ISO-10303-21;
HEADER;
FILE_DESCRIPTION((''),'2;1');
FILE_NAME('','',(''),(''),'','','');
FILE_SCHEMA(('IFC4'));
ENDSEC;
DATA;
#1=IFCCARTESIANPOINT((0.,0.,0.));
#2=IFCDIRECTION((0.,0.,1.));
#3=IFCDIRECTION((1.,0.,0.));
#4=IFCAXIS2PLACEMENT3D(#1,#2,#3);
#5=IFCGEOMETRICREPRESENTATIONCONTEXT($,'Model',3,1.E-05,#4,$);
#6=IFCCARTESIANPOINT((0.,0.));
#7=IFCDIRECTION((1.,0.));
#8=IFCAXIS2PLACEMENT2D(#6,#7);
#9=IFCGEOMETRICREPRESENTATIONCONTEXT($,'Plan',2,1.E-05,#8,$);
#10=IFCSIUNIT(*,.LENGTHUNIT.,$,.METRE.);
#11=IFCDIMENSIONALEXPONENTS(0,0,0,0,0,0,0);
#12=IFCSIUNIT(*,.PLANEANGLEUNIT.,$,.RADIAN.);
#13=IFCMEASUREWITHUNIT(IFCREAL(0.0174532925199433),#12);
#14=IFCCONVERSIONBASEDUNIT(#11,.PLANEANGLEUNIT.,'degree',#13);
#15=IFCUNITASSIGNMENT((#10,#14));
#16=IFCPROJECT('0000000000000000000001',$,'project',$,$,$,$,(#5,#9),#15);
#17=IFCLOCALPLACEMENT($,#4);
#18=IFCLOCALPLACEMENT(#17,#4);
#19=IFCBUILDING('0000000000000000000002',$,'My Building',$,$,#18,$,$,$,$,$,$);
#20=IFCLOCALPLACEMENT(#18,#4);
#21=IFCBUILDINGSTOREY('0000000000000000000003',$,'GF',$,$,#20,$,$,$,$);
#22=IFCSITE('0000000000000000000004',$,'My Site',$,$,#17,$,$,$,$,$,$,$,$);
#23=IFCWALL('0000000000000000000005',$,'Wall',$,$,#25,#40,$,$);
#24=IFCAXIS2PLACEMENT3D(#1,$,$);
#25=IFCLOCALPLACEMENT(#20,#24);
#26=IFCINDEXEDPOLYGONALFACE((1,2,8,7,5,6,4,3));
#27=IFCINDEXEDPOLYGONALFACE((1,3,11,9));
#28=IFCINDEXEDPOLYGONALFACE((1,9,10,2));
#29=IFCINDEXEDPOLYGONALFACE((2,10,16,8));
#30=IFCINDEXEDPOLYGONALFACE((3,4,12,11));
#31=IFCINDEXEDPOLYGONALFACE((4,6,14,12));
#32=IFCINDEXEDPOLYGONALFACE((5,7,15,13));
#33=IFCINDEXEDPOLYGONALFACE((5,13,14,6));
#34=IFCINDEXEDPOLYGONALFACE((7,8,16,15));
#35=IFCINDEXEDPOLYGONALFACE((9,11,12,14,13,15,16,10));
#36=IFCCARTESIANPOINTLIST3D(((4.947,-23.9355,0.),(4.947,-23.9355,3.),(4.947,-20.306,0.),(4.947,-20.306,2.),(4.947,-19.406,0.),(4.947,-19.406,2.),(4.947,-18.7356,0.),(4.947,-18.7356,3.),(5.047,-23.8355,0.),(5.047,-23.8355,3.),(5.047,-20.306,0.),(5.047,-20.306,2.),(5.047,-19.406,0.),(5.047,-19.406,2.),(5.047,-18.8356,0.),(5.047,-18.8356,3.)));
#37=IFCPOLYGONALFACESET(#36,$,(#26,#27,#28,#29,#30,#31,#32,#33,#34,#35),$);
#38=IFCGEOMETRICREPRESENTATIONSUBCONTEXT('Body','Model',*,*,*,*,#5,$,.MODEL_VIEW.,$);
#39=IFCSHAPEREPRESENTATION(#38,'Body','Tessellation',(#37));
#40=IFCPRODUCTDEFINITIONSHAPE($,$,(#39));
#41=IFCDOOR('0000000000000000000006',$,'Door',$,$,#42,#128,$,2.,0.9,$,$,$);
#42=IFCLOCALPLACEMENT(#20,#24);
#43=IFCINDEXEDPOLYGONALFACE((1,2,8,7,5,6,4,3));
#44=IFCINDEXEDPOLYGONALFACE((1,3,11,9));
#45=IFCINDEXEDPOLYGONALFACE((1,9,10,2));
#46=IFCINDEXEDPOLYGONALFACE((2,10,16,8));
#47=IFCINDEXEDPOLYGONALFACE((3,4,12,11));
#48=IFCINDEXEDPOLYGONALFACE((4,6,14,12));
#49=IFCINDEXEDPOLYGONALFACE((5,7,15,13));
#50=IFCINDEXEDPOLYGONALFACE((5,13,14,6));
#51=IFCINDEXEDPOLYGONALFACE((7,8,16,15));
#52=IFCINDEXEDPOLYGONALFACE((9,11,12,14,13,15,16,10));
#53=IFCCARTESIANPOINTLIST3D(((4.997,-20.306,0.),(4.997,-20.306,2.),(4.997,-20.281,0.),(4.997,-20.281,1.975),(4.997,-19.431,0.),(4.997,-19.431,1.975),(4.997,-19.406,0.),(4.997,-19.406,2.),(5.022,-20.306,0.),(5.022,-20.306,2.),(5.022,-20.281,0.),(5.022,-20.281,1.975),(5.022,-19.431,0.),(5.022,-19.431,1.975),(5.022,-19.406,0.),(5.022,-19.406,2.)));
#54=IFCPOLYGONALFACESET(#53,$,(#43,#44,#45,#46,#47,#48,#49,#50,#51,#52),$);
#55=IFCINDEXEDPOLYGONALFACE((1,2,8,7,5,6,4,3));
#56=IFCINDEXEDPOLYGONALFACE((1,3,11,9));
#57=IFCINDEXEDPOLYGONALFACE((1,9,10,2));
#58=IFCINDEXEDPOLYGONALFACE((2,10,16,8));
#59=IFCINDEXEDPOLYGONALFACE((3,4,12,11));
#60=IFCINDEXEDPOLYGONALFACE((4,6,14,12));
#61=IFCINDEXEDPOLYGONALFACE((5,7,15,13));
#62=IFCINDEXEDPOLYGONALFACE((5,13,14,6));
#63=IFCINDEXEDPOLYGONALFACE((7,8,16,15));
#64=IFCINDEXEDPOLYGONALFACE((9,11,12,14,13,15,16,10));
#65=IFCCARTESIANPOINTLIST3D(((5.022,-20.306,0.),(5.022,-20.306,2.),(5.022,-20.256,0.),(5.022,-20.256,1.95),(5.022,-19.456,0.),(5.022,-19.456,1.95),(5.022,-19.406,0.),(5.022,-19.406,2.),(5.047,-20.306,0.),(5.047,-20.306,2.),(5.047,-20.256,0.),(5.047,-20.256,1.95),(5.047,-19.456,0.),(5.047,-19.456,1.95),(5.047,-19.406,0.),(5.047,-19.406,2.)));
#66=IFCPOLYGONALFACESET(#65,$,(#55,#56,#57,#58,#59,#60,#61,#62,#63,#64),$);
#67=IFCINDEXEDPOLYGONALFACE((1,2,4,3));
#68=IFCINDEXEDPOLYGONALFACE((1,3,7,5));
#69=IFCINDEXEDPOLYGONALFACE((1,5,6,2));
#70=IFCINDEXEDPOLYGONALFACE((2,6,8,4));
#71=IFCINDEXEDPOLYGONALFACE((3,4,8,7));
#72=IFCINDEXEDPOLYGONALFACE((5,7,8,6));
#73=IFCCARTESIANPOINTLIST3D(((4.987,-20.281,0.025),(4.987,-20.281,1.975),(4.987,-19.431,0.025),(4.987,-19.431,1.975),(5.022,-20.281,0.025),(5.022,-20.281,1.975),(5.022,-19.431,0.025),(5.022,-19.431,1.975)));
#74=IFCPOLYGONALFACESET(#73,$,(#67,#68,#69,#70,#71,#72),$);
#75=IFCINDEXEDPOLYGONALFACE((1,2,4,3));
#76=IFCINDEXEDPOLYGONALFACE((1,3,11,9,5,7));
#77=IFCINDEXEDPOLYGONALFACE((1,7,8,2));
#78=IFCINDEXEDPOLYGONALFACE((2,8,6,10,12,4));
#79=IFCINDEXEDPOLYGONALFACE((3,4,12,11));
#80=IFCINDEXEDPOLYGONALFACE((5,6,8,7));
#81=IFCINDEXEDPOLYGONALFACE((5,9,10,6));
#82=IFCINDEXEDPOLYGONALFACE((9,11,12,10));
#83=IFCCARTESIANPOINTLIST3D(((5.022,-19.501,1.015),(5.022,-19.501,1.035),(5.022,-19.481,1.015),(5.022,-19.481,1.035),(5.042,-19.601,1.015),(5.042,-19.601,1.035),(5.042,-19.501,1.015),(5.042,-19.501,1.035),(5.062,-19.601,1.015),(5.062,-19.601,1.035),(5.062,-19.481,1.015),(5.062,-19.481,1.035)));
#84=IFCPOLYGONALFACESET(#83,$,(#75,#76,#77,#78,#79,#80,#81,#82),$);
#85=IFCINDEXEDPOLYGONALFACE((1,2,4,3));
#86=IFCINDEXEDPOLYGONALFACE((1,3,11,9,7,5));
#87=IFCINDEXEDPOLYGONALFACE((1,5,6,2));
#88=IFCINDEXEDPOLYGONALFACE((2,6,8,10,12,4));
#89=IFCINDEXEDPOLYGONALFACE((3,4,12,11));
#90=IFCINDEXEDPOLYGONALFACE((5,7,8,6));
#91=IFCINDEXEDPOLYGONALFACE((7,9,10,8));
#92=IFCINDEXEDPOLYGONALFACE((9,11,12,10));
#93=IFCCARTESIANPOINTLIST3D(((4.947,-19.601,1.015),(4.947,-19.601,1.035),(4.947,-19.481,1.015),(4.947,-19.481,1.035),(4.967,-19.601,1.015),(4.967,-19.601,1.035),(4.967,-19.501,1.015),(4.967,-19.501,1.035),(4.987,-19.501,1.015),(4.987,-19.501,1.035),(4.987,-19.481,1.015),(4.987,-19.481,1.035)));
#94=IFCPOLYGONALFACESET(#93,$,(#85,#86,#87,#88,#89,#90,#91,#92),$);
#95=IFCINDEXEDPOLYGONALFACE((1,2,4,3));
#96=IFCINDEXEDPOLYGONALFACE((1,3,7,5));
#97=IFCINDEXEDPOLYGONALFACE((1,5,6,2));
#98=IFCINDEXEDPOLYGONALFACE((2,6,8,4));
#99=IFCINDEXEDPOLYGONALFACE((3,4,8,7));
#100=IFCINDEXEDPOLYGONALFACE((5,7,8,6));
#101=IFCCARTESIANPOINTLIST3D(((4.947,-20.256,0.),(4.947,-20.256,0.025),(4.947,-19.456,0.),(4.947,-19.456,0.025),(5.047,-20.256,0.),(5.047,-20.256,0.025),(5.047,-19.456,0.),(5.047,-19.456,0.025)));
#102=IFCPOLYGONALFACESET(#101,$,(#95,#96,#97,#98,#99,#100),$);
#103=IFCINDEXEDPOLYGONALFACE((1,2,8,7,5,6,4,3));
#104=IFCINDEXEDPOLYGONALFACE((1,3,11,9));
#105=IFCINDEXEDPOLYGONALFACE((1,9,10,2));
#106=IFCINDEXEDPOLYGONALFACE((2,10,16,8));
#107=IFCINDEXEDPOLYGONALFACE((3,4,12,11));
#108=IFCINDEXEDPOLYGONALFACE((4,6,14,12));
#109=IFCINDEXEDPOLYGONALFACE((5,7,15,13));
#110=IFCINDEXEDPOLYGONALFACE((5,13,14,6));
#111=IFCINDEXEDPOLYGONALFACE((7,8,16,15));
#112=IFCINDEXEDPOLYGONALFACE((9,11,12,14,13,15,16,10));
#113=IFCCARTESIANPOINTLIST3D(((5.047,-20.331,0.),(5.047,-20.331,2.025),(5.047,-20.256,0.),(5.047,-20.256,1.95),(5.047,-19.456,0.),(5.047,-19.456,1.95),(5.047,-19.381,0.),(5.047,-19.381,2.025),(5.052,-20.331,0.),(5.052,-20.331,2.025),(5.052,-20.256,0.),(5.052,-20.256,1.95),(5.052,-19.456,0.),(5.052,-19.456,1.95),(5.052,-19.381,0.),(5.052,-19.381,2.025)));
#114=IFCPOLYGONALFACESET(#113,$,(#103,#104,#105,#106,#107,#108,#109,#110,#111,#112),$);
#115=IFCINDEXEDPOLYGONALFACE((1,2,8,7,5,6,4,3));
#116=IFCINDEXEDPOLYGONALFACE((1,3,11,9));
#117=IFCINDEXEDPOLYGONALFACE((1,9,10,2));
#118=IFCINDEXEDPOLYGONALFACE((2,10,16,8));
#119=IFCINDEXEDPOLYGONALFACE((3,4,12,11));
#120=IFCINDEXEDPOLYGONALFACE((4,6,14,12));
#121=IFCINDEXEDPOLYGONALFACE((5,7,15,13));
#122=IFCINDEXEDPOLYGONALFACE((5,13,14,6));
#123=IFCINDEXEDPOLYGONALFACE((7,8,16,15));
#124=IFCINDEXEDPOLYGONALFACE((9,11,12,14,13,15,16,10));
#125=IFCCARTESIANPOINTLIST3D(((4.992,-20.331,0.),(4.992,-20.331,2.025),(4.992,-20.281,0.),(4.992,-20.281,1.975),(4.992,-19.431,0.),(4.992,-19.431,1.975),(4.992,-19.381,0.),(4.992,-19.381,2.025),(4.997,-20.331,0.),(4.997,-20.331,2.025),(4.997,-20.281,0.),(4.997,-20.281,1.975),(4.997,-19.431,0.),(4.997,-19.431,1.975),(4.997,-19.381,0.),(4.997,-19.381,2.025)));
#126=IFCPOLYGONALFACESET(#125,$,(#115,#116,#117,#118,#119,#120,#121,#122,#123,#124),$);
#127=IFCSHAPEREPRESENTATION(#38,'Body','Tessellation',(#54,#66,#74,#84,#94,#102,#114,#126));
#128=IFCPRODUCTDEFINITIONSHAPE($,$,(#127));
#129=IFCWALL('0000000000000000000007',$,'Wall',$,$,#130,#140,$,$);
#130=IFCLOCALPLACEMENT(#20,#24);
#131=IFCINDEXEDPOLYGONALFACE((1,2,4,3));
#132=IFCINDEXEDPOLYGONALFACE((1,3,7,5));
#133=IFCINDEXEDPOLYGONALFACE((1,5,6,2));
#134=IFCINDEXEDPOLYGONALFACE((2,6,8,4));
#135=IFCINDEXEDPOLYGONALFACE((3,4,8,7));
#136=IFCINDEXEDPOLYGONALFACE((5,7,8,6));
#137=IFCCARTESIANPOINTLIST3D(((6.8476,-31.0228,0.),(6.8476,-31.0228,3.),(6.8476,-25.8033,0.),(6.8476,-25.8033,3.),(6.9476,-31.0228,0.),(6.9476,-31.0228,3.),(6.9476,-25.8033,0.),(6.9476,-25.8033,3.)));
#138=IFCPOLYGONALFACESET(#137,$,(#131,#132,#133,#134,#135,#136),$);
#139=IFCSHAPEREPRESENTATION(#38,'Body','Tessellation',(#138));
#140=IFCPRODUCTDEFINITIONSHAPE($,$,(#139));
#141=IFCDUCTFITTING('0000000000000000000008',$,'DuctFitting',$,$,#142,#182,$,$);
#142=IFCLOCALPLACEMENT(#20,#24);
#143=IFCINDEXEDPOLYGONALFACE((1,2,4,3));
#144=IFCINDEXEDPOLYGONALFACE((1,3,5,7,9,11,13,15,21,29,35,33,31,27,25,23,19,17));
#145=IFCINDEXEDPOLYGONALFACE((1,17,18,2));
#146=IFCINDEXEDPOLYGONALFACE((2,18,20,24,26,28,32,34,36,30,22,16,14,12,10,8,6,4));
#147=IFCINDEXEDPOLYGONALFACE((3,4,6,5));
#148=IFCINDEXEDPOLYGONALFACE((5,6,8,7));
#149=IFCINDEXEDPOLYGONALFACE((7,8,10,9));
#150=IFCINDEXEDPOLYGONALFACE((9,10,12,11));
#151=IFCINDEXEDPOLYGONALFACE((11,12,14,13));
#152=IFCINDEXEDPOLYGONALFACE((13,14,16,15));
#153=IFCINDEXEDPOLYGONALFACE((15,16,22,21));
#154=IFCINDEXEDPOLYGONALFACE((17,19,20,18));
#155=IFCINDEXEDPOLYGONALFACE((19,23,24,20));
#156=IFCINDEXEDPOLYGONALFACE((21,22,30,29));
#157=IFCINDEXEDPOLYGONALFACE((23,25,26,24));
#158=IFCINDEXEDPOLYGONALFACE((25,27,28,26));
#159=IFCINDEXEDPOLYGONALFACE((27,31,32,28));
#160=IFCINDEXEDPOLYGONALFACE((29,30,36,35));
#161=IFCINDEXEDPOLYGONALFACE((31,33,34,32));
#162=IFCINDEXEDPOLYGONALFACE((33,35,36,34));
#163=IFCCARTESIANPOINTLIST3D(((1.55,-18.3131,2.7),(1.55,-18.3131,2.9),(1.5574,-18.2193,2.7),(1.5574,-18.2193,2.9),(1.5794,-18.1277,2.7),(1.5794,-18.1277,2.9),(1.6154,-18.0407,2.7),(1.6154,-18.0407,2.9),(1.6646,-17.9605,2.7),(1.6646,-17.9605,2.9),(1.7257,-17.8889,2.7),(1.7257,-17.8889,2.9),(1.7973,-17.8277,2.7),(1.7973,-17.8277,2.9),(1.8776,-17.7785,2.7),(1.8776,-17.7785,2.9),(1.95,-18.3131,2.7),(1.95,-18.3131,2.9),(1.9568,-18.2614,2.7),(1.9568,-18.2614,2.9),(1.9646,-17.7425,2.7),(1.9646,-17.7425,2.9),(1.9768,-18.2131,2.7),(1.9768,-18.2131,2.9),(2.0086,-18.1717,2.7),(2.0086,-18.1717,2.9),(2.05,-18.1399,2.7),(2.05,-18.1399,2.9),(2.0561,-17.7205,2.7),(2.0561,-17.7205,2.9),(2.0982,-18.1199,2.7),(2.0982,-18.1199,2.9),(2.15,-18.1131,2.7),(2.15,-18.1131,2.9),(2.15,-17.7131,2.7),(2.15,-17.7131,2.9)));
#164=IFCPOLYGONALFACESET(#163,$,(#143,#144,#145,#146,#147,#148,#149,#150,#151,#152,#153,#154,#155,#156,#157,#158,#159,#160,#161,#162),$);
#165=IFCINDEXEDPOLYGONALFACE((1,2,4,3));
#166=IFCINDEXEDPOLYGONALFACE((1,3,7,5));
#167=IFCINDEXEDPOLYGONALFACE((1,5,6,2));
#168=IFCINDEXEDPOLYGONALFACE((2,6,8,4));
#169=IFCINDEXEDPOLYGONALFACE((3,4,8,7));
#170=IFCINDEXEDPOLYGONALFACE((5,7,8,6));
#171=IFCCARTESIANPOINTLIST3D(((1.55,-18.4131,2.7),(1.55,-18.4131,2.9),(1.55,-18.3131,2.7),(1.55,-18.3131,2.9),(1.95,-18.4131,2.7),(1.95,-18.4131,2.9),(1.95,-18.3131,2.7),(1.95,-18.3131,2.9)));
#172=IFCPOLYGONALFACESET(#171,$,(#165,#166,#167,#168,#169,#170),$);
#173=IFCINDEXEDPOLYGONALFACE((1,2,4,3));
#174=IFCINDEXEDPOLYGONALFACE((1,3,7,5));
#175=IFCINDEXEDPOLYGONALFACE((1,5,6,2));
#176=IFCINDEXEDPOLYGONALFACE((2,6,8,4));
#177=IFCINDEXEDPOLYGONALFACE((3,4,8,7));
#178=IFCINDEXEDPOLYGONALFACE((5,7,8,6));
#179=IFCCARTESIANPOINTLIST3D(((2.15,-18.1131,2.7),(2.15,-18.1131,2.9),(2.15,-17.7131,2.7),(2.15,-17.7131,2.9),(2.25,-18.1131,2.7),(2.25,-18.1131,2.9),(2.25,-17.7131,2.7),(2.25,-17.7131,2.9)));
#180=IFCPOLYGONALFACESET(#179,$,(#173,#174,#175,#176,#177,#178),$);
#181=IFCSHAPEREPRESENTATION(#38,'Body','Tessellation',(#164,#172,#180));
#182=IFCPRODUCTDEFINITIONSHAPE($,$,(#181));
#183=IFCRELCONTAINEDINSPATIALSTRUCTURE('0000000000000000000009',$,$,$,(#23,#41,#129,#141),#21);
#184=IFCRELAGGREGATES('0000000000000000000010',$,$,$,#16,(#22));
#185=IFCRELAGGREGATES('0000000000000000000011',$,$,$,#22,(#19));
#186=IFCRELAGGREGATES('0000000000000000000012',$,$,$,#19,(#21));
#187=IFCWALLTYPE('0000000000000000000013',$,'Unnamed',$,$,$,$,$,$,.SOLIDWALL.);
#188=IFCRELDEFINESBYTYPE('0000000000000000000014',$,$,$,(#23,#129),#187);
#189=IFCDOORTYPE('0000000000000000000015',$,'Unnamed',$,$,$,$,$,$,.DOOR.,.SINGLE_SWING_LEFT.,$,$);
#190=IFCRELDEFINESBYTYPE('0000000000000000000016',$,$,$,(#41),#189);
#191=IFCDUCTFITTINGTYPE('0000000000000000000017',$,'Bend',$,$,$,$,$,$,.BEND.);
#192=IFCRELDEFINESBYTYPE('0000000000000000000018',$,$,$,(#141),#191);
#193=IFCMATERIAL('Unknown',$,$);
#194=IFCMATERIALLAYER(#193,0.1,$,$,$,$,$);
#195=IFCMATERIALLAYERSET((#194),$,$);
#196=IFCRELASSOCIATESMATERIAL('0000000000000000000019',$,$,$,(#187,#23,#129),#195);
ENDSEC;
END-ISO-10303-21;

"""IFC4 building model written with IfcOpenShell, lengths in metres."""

from ifc_helpers import new_model, entity, si_unit, converted_unit, frame, origin_with_axes, origin_2d_with_axis, place, context, subcontext, project, spatial, line, arc, indexed_curve, rectangle, outline, extrude, shape, source, transform, mapped, material, layer, layer_set, layer_usage, type_object, type_shapes, element, fill, save


model = new_model("IFC4")

# Units and contexts
model_context = context("Model", 3, precision=1e-05, world=origin_with_axes())
plan_context = context("Plan", 2, precision=1e-05, world=origin_2d_with_axis())
body_context_1 = subcontext(model_context, "Body", "Model", "MODEL_VIEW")
body_context_2 = subcontext(plan_context, "Body", "Plan", "PLAN_VIEW")
ifc_project = project(units=[si_unit("LENGTHUNIT", "METRE"), converted_unit("PLANEANGLEUNIT", "degree", entity("IfcReal", 0.0174532925199433), si_unit("PLANEANGLEUNIT", "RADIAN"), dimensions=[0, 0, 0, 0, 0, 0, 0])], contexts=[model_context, plan_context])

# Site, building, storey
site_placement = place(None, origin_with_axes())
site = spatial("IfcSite", under=ifc_project, at=site_placement, Name="My Site")
building_placement = place(site_placement, origin_with_axes())
building = spatial("IfcBuilding", under=site, at=building_placement, Name="My Building")
storey_placement = place(building_placement, origin_with_axes())
storey = spatial("IfcBuildingStorey", under=building, at=storey_placement, Name="GF")

# Shared definitions
ifc_material = material(Name="Unknown")

# Shared definitions
ifc_layer_1 = layer(ifc_material, 0.1)
ifc_layer_set_1 = layer_set([ifc_layer_1])
wall_type = type_object("IfcWallType", Name="Unnamed", PredefinedType="SOLIDWALL", material=ifc_layer_set_1)

# Shared definitions
shared_shape_1 = source(origin_with_axes(), body_context_1, "Body", "SweptSolid", [
    extrude(outline(indexed_curve([(0.0, 0.0), (0.9, 0.0), (0.9, 2.0), (0.0, 2.0)], segments=[line(1, 2, 3, 4, 1)])), frame((0.0, -0.6, 0.0), z_axis=(0.0, -1.0, 0.0), x_axis=(1.0, 0.0, 0.0)), (0.0, 0.0, -1.0), 1.2),
])
door_type = type_object("IfcDoorType", Name="Unnamed", OperationType="SINGLE_SWING_LEFT", PredefinedType="DOOR")
shared_shape_2 = source(origin_with_axes(), body_context_1, "Body", "SweptSolid", [
    extrude(outline(indexed_curve([(0.0, 0.0), (0.0, 2.0), (0.9, 2.0), (0.9, 0.0), (0.875, 0.0), (0.875, 1.975), (0.025, 1.975), (0.025, 0.0)], segments=[line(1, 2, 3, 4, 5, 6, 7, 8, 1)])), frame((0.0, 0.025, 0.0), z_axis=(0.0, -1.0, 0.0), x_axis=(1.0, 0.0, 0.0)), (0.0, 0.0, -1.0), 0.025),
    extrude(outline(indexed_curve([(0.0, 0.0), (0.0, 2.0), (0.9, 2.0), (0.9, 0.0), (0.85, 0.0), (0.85, 1.95), (0.05, 1.95), (0.05, 0.0)], segments=[line(1, 2, 3, 4, 5, 6, 7, 8, 1)])), frame((0.0, 0.0, 0.0), z_axis=(0.0, -1.0, 0.0), x_axis=(1.0, 0.0, 0.0)), (0.0, 0.0, -1.0), 0.025),
    extrude(outline(indexed_curve([(0.0, 0.0), (0.85, 0.0), (0.85, 0.035), (0.0, 0.035)], segments=[line(1, 2, 3, 4, 1)])), frame((0.025, 0.025, 0.025), z_axis=(0.0, 0.0, 1.0), x_axis=(1.0, 0.0, 0.0)), (0.0, 0.0, 1.0), 1.95),
    extrude(outline(indexed_curve([(0.0, 0.0), (0.0, -0.04), (-0.12, -0.04), (-0.12, -0.02), (-0.02, -0.02), (-0.02, 0.0)], segments=[line(1, 2, 3, 4, 5, 6, 1)])), frame((0.825, 0.025, 1.015), z_axis=(0.0, 0.0, 1.0), x_axis=(1.0, 0.0, 0.0)), (0.0, 0.0, 1.0), 0.02),
    extrude(outline(indexed_curve([(0.0, 0.0), (0.0, 0.04), (-0.12, 0.04), (-0.12, 0.02), (-0.02, 0.02), (-0.02, 0.0)], segments=[line(1, 2, 3, 4, 5, 6, 1)])), frame((0.825, 0.06, 1.015), z_axis=(0.0, 0.0, 1.0), x_axis=(1.0, 0.0, 0.0)), (0.0, 0.0, 1.0), 0.02),
    extrude(outline(indexed_curve([(0.0, 0.0), (0.8, 0.0), (0.8, 0.1), (0.0, 0.1)], segments=[line(1, 2, 3, 4, 1)])), frame((0.05, 0.0, 0.0), z_axis=(0.0, 0.0, 1.0), x_axis=(1.0, 0.0, 0.0)), (0.0, 0.0, 1.0), 0.025),
    extrude(outline(indexed_curve([(0.0, 0.0), (0.0, 2.025), (0.95, 2.025), (0.95, 0.0), (0.875, 0.0), (0.875, 1.95), (0.075, 1.95), (0.075, 0.0)], segments=[line(1, 2, 3, 4, 5, 6, 7, 8, 1)])), frame((-0.025, -0.005, 0.0), z_axis=(0.0, -1.0, 0.0), x_axis=(1.0, 0.0, 0.0)), (0.0, 0.0, -1.0), 0.005),
    extrude(outline(indexed_curve([(0.0, 0.0), (0.0, 2.025), (0.95, 2.025), (0.95, 0.0), (0.9, 0.0), (0.9, 1.975), (0.05, 1.975), (0.05, 0.0)], segments=[line(1, 2, 3, 4, 5, 6, 7, 8, 1)])), frame((-0.025, 0.05, 0.0), z_axis=(0.0, -1.0, 0.0), x_axis=(1.0, 0.0, 0.0)), (0.0, 0.0, -1.0), 0.005),
])
shared_shape_3 = source(origin_with_axes(), body_context_2, "Body", "Curve2D", [
    entity("IfcIndexedPolyCurve", entity("IfcCartesianPointList2D", [[0.0, 0.0], [0.0, 0.05], [0.025, 0.05], [0.025, 0.025], [0.05, 0.025], [0.05, 0.0]]), [entity("IfcLineIndex", [1, 2, 3, 4, 5, 6, 1])]),
    entity("IfcIndexedPolyCurve", entity("IfcCartesianPointList2D", [[0.9, 0.0], [0.9, 0.05], [0.875, 0.05], [0.875, 0.025], [0.85, 0.025], [0.85, 0.0]]), [entity("IfcLineIndex", [1, 2, 3, 4, 5, 6, 1])]),
    entity("IfcTrimmedCurve", entity("IfcEllipse", entity("IfcAxis2Placement2D", entity("IfcCartesianPoint", [0.06, 0.05]), entity("IfcDirection", [1.0, 0.0])), 0.815, 0.85), [entity("IfcCartesianPoint", [0.875, 0.05])], [entity("IfcCartesianPoint", [0.06, 0.9])], True, "CARTESIAN"),
    entity("IfcIndexedPolyCurve", entity("IfcCartesianPointList2D", [[0.025, 0.05], [0.06, 0.05], [0.06, 0.9], [0.025, 0.9]]), [entity("IfcLineIndex", [1, 2, 3, 4, 1])]),
])
type_shapes(door_type, [shared_shape_2, shared_shape_3])

# Wall, opening, door
ifc_layer_usage_1 = layer_usage(ifc_layer_set_1, "AXIS2", "POSITIVE", 0.0)
wall_1_placement = place(storey_placement, frame((5.047, -23.8355, 0.0), z_axis=(0.0, 0.0, 1.0), x_axis=(0.0, 1.0, 0.0)))
wall_1 = element("IfcWall", 1, at=wall_1_placement, inside=storey, type_object=wall_type, material=ifc_layer_usage_1, Name="Wall", context=body_context_1, shape_type="SweptSolid", body=[
    extrude(outline(indexed_curve([(0.0, 0.0), (-0.1, 0.1), (5.1, 0.1), (5.0, 0.0)], segments=[line(1, 2, 3, 4, 1)])), origin_with_axes(), (0.0, 0.0, 1.0), 3.0),
])
opening_1_placement = place(wall_1_placement, frame((3.5295, 0.0, 0.0), z_axis=(0.0, 0.0, 1.0), x_axis=(1.0, 0.0, 0.0)))
opening_1 = element("IfcOpeningElement", 2, at=opening_1_placement, cuts=wall_1, PredefinedType="OPENING", context=body_context_1, shape_type="MappedRepresentation", body=[
    mapped(shared_shape_1, transform((0.0, 0.0, 0.0), x_axis=(1.0, 0.0, 0.0), y_axis=(0.0, 1.0, 0.0), z_axis=(0.0, 0.0, 1.0), scale=1.0)),
])
door_1_placement = place(opening_1_placement, frame((0.0, 0.0, 0.0), z_axis=(0.0, 0.0, 1.0), x_axis=(1.0, 0.0, 0.0)))
door_1 = element("IfcDoor", 3, at=door_1_placement, inside=storey, type_object=door_type, Name="Door", OverallHeight=2.0, OverallWidth=0.9, shapes=[
    shape(body_context_1, "Body", "MappedRepresentation", [mapped(shared_shape_2, transform((0.0, 0.0, 0.0), x_axis=(1.0, 0.0, 0.0), y_axis=(0.0, 1.0, 0.0), z_axis=(0.0, 0.0, 1.0), scale=1.0))]),
    shape(body_context_2, "Body", "MappedRepresentation", [mapped(shared_shape_3, transform((0.0, 0.0, 0.0), x_axis=(1.0, 0.0, 0.0), y_axis=(0.0, 1.0, 0.0), z_axis=(0.0, 0.0, 1.0), scale=1.0))]),
])
fill(opening_1, door_1)

# Wall
ifc_layer_usage_2 = layer_usage(ifc_layer_set_1, "AXIS2", "POSITIVE", 0.0)
wall_2_placement = place(storey_placement, frame((6.8476, -25.8033, 0.0), z_axis=(0.0, 0.0, 1.0), x_axis=(0.0, -1.0, 0.0)))
element("IfcWall", 4, at=wall_2_placement, inside=storey, type_object=wall_type, material=ifc_layer_usage_2, Name="Wall", context=body_context_1, shape_type="SweptSolid", body=[
    extrude(outline(indexed_curve([(0.0, 0.0), (0.0, 0.1), (5.2195, 0.1), (5.2195, 0.0)], segments=[line(1, 2, 3, 4, 1)])), origin_with_axes(), (0.0, 0.0, 1.0), 3.0),
])

# Duct fitting
duct_fitting_type = type_object("IfcDuctFittingType", Name="Bend", PredefinedType="BEND")
shared_shape_4 = source(origin_with_axes(), body_context_1, "Body", "SweptSolid", [
    extrude(outline(indexed_curve([(-0.2, 0.0), (-0.2586, -0.1414), (-0.4, -0.2), (-0.4, -0.6), (0.0243, -0.4243), (0.2, 0.0)], segments=[arc(1, 2, 3), line(3, 4), arc(4, 5, 6), line(6, 1)])), frame((0.0, -0.1, -0.1), z_axis=(0.0, -1.0, 0.0), x_axis=(1.0, 0.0, 0.0)), (0.0, 0.0, -1.0), 0.2),
    extrude(rectangle(XDim=0.4, YDim=0.2), origin_with_axes(), (0.0, 0.0, -1.0), 0.1),
    extrude(rectangle(XDim=0.4, YDim=0.2), frame((-0.4, 0.0, -0.5), z_axis=(-1.0, 0.0, 0.0), x_axis=(0.0, 0.0, -1.0)), (0.0, 0.0, 1.0), 0.1),
])
type_shapes(duct_fitting_type, [shared_shape_4])
for number, where, z_axis, x_axis, name in (
    (5, (1.75, -18.4131, 2.8), (0.0, -1.0, 0.0), (-1.0, 0.0, 0.0), "DuctFitting"),
):
    element("IfcDuctFitting", number, at=place(storey_placement, frame(where, z_axis=z_axis, x_axis=x_axis)), inside=storey, type_object=duct_fitting_type, Name=name, context=body_context_1, shape_type="MappedRepresentation", body=[
        mapped(shared_shape_4, transform((0.0, 0.0, 0.0), x_axis=(1.0, 0.0, 0.0), y_axis=(0.0, 1.0, 0.0), z_axis=(0.0, 0.0, 1.0), scale=1.0)),
    ])

save(model, "model.ifc")
